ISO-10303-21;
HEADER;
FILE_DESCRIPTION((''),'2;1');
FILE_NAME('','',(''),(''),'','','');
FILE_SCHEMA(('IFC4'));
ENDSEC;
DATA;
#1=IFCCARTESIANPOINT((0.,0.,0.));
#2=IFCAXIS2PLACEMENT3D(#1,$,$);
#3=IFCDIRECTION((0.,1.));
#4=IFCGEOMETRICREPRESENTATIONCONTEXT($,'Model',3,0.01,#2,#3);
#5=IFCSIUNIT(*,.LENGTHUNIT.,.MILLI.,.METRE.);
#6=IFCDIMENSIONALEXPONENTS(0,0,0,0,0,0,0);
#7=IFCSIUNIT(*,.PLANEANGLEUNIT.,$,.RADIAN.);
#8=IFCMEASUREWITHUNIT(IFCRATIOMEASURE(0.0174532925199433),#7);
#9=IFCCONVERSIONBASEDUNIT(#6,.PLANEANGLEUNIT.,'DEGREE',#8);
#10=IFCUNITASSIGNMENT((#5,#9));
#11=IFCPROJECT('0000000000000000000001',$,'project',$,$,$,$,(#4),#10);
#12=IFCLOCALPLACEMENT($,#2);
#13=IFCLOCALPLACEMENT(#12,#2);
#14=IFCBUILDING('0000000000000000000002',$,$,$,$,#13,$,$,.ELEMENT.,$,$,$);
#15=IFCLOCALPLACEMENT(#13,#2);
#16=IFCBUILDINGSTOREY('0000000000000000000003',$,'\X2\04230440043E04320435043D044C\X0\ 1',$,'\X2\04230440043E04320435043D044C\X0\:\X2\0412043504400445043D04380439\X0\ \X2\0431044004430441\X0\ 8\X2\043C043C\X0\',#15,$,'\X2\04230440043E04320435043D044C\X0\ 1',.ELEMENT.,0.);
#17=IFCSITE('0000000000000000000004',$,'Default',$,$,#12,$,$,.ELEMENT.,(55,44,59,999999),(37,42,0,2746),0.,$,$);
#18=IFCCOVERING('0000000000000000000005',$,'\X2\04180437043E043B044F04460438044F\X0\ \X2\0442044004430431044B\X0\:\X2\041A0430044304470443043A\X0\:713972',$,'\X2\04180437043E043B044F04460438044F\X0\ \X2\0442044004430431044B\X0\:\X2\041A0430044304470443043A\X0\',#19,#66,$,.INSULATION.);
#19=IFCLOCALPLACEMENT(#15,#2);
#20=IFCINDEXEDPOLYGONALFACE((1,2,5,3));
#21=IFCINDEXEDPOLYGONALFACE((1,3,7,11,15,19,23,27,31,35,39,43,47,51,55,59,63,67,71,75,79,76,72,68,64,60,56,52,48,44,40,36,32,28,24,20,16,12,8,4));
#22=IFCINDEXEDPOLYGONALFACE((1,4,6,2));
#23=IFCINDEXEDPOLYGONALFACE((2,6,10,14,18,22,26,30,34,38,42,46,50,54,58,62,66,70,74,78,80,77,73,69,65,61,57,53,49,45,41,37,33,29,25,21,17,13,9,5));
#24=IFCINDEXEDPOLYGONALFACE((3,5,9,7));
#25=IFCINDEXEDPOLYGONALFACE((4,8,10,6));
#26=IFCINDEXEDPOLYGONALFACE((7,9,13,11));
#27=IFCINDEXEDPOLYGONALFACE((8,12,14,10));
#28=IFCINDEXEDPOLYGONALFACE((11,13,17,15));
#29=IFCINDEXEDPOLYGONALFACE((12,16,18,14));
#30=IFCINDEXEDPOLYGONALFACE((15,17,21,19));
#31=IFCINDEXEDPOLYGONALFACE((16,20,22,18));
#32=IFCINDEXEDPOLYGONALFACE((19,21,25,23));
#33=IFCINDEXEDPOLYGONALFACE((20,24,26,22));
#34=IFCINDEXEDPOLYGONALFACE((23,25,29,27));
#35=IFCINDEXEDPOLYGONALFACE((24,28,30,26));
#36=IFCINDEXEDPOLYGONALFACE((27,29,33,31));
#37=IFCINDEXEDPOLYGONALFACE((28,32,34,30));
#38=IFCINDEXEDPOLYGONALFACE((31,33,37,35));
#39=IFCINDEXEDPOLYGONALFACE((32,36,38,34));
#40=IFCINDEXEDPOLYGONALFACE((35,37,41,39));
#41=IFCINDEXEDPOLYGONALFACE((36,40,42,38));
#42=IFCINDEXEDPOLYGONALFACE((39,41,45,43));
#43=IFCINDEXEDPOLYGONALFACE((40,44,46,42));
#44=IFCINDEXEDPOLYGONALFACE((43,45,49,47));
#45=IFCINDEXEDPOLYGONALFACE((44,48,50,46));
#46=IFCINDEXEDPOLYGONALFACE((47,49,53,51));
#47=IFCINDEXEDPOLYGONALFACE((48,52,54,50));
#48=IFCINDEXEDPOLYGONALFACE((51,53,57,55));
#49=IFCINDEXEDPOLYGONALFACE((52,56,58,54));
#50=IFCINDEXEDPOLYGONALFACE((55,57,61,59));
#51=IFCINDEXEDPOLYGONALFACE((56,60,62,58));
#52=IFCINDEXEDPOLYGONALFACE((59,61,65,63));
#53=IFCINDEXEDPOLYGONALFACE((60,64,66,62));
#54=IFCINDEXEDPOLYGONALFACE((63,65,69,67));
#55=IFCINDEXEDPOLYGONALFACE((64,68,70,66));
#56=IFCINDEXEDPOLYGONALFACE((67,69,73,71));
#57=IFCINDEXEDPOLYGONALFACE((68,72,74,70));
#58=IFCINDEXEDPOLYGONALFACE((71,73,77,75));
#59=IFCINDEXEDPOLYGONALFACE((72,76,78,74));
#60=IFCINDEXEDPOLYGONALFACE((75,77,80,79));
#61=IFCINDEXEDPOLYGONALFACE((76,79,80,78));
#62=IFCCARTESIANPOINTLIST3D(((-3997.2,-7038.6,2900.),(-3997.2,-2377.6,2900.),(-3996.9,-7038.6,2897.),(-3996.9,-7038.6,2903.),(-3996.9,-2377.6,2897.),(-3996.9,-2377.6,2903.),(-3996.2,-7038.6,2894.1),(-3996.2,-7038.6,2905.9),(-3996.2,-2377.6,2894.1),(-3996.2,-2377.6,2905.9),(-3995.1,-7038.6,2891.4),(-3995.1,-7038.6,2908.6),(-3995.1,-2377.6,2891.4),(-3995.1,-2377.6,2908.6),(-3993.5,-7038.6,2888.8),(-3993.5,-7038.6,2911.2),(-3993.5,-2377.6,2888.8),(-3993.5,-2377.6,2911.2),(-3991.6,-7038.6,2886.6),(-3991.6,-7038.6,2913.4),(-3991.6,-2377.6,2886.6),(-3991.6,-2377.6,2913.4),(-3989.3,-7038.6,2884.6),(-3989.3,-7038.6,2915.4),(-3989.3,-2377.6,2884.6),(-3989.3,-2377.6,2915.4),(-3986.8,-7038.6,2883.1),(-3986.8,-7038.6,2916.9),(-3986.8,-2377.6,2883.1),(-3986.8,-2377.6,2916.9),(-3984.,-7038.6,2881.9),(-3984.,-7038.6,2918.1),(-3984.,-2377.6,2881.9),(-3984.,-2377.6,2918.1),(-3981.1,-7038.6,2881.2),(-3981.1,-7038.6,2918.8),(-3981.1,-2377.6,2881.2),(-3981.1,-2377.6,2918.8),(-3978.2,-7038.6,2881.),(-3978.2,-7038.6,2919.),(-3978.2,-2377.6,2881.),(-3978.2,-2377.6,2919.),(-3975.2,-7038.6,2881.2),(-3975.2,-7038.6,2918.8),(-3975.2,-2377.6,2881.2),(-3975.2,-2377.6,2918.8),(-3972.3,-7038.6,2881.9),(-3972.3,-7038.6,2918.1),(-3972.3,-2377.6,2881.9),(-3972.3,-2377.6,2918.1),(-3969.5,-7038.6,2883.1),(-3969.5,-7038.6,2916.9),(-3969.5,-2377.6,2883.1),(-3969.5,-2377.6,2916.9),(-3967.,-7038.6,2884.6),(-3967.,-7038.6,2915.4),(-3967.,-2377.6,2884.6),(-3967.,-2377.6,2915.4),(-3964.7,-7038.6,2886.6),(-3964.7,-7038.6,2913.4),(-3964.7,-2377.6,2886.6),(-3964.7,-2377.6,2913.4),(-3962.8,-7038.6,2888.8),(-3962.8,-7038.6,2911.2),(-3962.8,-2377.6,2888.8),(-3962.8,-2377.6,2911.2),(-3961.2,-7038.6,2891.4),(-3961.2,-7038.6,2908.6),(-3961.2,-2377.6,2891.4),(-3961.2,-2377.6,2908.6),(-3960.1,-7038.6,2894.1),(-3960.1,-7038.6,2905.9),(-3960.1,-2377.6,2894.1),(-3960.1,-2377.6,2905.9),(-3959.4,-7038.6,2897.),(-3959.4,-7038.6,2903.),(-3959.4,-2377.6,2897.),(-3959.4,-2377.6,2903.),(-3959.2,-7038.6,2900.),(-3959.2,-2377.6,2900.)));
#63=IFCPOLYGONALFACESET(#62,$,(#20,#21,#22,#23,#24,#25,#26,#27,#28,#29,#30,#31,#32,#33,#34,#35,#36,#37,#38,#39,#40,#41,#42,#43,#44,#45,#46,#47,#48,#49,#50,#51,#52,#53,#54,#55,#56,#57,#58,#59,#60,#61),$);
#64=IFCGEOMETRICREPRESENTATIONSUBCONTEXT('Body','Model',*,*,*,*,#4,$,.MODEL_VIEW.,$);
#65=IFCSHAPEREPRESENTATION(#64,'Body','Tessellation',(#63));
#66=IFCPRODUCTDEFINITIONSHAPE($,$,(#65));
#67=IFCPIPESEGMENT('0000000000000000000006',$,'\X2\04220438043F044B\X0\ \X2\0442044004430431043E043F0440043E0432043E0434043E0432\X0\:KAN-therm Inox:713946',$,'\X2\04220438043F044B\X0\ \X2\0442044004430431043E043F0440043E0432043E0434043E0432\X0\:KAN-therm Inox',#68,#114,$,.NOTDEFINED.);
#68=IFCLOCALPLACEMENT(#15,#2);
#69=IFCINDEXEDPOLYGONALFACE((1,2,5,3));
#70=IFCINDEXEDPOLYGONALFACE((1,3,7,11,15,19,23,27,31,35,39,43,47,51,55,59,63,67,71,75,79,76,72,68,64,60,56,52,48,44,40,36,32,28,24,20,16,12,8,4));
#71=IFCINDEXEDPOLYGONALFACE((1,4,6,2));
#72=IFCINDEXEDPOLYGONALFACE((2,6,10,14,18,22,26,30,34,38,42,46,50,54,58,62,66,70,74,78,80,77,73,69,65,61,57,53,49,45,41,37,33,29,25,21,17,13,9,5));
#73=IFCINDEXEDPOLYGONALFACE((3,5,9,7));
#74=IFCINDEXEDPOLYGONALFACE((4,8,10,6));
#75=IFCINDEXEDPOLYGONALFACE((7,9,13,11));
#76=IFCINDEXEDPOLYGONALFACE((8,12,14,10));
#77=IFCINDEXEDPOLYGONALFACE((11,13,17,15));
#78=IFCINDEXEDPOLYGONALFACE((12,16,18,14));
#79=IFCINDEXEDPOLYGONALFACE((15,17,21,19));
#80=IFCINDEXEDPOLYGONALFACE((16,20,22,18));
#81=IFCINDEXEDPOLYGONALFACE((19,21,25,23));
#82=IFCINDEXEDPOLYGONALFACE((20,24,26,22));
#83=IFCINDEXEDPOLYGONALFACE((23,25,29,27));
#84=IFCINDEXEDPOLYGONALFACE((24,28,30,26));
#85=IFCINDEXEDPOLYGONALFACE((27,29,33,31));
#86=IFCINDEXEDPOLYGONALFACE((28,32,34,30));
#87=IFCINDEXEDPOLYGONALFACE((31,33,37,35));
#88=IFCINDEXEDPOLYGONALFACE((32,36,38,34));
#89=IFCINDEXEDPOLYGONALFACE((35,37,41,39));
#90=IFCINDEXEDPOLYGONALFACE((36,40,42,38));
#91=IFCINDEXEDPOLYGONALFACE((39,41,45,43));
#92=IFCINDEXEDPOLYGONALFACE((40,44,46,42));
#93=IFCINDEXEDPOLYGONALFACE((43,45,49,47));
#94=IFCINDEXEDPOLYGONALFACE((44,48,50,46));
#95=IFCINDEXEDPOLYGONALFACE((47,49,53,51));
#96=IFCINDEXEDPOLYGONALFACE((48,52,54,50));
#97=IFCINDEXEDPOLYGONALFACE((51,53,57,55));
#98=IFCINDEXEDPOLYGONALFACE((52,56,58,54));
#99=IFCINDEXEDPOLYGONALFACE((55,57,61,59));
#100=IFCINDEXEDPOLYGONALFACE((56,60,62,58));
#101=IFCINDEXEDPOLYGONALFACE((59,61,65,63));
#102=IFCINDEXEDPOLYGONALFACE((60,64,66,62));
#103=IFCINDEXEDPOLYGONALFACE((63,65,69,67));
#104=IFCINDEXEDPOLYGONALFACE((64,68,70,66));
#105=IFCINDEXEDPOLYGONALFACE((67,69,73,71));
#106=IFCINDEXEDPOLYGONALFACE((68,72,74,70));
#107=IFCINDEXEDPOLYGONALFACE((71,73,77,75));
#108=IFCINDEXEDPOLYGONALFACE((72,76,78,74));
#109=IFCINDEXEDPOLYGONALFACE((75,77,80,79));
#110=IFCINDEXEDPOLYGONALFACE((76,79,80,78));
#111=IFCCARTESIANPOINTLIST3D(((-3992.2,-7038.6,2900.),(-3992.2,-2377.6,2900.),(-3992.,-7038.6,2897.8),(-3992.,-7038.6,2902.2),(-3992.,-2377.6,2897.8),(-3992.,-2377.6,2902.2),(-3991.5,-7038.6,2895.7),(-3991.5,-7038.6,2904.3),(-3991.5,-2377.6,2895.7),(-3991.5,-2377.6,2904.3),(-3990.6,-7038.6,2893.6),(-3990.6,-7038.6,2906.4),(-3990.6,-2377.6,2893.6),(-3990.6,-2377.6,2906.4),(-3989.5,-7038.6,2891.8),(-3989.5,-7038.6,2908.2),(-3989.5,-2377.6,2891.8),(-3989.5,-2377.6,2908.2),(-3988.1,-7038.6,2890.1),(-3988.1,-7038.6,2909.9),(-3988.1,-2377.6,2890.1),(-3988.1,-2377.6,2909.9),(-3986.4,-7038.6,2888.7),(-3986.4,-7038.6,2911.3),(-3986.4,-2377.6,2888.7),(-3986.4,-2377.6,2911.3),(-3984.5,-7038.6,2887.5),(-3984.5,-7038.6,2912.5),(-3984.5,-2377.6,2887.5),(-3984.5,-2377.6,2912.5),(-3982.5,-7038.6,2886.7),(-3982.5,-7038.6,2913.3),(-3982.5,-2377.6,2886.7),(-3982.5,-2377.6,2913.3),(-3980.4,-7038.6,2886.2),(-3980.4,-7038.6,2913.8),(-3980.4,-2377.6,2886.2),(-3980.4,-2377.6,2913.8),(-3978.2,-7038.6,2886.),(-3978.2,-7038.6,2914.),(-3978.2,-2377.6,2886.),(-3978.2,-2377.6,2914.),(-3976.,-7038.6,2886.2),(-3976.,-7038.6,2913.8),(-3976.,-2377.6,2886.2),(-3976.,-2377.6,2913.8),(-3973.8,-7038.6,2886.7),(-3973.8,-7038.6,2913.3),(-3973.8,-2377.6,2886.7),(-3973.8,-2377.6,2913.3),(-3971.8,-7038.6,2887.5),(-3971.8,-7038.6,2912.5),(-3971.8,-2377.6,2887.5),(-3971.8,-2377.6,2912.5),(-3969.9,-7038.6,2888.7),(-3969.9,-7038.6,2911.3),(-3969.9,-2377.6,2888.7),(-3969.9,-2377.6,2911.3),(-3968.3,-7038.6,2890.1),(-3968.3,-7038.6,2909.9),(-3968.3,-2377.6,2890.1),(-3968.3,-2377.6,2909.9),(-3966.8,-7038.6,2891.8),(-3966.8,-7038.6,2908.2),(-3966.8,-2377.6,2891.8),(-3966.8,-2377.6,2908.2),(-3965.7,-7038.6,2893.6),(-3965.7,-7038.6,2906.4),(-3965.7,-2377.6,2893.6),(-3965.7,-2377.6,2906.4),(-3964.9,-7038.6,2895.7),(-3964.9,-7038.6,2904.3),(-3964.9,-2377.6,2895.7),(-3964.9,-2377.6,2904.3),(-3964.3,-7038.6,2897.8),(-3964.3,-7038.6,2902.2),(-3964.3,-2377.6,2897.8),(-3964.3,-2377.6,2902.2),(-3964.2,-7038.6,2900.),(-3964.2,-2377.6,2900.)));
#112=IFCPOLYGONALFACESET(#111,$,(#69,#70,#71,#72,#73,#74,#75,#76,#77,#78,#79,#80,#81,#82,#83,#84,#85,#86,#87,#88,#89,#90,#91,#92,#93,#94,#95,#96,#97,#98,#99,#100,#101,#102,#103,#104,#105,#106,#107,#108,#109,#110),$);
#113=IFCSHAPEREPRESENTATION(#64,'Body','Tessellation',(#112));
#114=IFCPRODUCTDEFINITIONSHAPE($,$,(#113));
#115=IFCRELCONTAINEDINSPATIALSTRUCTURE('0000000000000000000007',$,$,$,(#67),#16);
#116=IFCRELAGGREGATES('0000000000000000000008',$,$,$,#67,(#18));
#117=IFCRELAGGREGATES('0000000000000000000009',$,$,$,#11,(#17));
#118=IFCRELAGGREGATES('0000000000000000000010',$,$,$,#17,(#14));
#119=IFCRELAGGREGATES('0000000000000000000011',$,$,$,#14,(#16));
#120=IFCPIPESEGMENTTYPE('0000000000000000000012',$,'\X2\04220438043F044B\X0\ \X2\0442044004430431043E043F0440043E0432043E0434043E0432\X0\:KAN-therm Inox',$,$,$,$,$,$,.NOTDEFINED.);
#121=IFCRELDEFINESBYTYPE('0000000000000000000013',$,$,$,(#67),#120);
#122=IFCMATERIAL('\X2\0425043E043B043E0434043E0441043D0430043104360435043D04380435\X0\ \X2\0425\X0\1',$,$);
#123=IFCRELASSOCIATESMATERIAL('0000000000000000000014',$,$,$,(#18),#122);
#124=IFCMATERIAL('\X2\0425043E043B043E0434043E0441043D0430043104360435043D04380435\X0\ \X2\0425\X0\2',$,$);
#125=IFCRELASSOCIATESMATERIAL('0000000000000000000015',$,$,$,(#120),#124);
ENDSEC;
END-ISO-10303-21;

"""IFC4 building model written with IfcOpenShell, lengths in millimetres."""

from ifc_helpers import new_model, entity, si_unit, converted_unit, direction, frame, origin, place, context, subcontext, project, spatial, indexed_curve, outline, extrude, material, type_object, element, aggregate, save


model = new_model("IFC4")

# Units and contexts
model_context = context("Model", 3, precision=0.01, world=origin(), true_north=direction((0.0, 1.0)))
body_context = subcontext(model_context, "Body", "Model", "MODEL_VIEW")
ifc_project = project(units=[si_unit("LENGTHUNIT", "METRE", prefix="MILLI"), converted_unit("PLANEANGLEUNIT", "DEGREE", entity("IfcRatioMeasure", 0.0174532925199433), si_unit("PLANEANGLEUNIT", "RADIAN"), dimensions=[0, 0, 0, 0, 0, 0, 0])], contexts=[model_context])

# Site, building, storey
site_placement = place(None, origin())
site = spatial("IfcSite", under=ifc_project, at=site_placement, Name="Default", CompositionType="ELEMENT", RefLatitude=(55, 44, 59, 999999), RefLongitude=(37, 42, 0, 2746), RefElevation=0.0)
building_placement = place(site_placement, origin())
building = spatial("IfcBuilding", under=site, at=building_placement, CompositionType="ELEMENT")
storey_placement = place(building_placement, origin())
storey = spatial("IfcBuildingStorey", under=building, at=storey_placement, Name="Уровень 1", ObjectType="Уровень:Верхний брус 8мм", LongName="Уровень 1", CompositionType="ELEMENT", Elevation=0.0)

# Covering
ifc_material_1 = material(Name="Холодоснабжение Х2")
ifc_material_2 = material(Name="Холодоснабжение Х1")
covering_1_placement = place(storey_placement, origin())
covering_1 = element("IfcCovering", 1, at=covering_1_placement, material=ifc_material_2, Name="Изоляция трубы:Каучук:713972", ObjectType="Изоляция трубы:Каучук", PredefinedType="INSULATION", context=body_context, shape_type="SweptSolid", body=[
    extrude(outline(indexed_curve([(19.0, 0.0), (18.8, 3.0), (18.1, 5.9), (16.9, 8.6), (15.4, 11.2), (13.4, 13.4), (11.2, 15.4), (8.6, 16.9), (5.9, 18.1), (3.0, 18.8), (0.0, 19.0), (-3.0, 18.8), (-5.9, 18.1), (-8.6, 16.9), (-11.2, 15.4), (-13.4, 13.4), (-15.4, 11.2), (-16.9, 8.6), (-18.1, 5.9), (-18.8, 3.0), (-19.0, 0.0), (-18.8, -3.0), (-18.1, -5.9), (-16.9, -8.6), (-15.4, -11.2), (-13.4, -13.4), (-11.2, -15.4), (-8.6, -16.9), (-5.9, -18.1), (-3.0, -18.8), (0.0, -19.0), (3.0, -18.8), (5.9, -18.1), (8.6, -16.9), (11.2, -15.4), (13.4, -13.4), (15.4, -11.2), (16.9, -8.6), (18.1, -5.9), (18.8, -3.0), (19.0, 0.0)], self_intersect=False)), frame((-3978.2, -7038.6, 2900.0), z_axis=(0.0, 1.0, 0.0), x_axis=(1.0, 0.0, 0.0)), (0.0, 0.0, 1.0), 4661.0),
])

# Pipe segment
pipe_segment_type_1 = type_object("IfcPipeSegmentType", Name="Типы трубопроводов:KAN-therm Inox", PredefinedType="NOTDEFINED", material=ifc_material_1)
pipe_segment_1_placement = place(storey_placement, origin())
pipe_segment_1 = element("IfcPipeSegment", 2, at=pipe_segment_1_placement, inside=storey, type_object=pipe_segment_type_1, Name="Типы трубопроводов:KAN-therm Inox:713946", ObjectType="Типы трубопроводов:KAN-therm Inox", PredefinedType="NOTDEFINED", context=body_context, shape_type="SweptSolid", body=[
    extrude(outline(indexed_curve([(14.0, 0.0), (13.8, 2.2), (13.3, 4.3), (12.5, 6.4), (11.3, 8.2), (9.9, 9.9), (8.2, 11.3), (6.4, 12.5), (4.3, 13.3), (2.2, 13.8), (0.0, 14.0), (-2.2, 13.8), (-4.3, 13.3), (-6.4, 12.5), (-8.2, 11.3), (-9.9, 9.9), (-11.3, 8.2), (-12.5, 6.4), (-13.3, 4.3), (-13.8, 2.2), (-14.0, 0.0), (-13.8, -2.2), (-13.3, -4.3), (-12.5, -6.4), (-11.3, -8.2), (-9.9, -9.9), (-8.2, -11.3), (-6.4, -12.5), (-4.3, -13.3), (-2.2, -13.8), (0.0, -14.0), (2.2, -13.8), (4.3, -13.3), (6.4, -12.5), (8.2, -11.3), (9.9, -9.9), (11.3, -8.2), (12.5, -6.4), (13.3, -4.3), (13.8, -2.2), (14.0, 0.0)], self_intersect=False)), frame((-3978.2, -7038.6, 2900.0), z_axis=(0.0, 1.0, 0.0), x_axis=(-1.0, 0.0, 0.0)), (0.0, 0.0, 1.0), 4661.0),
])
aggregate(pipe_segment_1, [covering_1])

save(model, "model.ifc")
